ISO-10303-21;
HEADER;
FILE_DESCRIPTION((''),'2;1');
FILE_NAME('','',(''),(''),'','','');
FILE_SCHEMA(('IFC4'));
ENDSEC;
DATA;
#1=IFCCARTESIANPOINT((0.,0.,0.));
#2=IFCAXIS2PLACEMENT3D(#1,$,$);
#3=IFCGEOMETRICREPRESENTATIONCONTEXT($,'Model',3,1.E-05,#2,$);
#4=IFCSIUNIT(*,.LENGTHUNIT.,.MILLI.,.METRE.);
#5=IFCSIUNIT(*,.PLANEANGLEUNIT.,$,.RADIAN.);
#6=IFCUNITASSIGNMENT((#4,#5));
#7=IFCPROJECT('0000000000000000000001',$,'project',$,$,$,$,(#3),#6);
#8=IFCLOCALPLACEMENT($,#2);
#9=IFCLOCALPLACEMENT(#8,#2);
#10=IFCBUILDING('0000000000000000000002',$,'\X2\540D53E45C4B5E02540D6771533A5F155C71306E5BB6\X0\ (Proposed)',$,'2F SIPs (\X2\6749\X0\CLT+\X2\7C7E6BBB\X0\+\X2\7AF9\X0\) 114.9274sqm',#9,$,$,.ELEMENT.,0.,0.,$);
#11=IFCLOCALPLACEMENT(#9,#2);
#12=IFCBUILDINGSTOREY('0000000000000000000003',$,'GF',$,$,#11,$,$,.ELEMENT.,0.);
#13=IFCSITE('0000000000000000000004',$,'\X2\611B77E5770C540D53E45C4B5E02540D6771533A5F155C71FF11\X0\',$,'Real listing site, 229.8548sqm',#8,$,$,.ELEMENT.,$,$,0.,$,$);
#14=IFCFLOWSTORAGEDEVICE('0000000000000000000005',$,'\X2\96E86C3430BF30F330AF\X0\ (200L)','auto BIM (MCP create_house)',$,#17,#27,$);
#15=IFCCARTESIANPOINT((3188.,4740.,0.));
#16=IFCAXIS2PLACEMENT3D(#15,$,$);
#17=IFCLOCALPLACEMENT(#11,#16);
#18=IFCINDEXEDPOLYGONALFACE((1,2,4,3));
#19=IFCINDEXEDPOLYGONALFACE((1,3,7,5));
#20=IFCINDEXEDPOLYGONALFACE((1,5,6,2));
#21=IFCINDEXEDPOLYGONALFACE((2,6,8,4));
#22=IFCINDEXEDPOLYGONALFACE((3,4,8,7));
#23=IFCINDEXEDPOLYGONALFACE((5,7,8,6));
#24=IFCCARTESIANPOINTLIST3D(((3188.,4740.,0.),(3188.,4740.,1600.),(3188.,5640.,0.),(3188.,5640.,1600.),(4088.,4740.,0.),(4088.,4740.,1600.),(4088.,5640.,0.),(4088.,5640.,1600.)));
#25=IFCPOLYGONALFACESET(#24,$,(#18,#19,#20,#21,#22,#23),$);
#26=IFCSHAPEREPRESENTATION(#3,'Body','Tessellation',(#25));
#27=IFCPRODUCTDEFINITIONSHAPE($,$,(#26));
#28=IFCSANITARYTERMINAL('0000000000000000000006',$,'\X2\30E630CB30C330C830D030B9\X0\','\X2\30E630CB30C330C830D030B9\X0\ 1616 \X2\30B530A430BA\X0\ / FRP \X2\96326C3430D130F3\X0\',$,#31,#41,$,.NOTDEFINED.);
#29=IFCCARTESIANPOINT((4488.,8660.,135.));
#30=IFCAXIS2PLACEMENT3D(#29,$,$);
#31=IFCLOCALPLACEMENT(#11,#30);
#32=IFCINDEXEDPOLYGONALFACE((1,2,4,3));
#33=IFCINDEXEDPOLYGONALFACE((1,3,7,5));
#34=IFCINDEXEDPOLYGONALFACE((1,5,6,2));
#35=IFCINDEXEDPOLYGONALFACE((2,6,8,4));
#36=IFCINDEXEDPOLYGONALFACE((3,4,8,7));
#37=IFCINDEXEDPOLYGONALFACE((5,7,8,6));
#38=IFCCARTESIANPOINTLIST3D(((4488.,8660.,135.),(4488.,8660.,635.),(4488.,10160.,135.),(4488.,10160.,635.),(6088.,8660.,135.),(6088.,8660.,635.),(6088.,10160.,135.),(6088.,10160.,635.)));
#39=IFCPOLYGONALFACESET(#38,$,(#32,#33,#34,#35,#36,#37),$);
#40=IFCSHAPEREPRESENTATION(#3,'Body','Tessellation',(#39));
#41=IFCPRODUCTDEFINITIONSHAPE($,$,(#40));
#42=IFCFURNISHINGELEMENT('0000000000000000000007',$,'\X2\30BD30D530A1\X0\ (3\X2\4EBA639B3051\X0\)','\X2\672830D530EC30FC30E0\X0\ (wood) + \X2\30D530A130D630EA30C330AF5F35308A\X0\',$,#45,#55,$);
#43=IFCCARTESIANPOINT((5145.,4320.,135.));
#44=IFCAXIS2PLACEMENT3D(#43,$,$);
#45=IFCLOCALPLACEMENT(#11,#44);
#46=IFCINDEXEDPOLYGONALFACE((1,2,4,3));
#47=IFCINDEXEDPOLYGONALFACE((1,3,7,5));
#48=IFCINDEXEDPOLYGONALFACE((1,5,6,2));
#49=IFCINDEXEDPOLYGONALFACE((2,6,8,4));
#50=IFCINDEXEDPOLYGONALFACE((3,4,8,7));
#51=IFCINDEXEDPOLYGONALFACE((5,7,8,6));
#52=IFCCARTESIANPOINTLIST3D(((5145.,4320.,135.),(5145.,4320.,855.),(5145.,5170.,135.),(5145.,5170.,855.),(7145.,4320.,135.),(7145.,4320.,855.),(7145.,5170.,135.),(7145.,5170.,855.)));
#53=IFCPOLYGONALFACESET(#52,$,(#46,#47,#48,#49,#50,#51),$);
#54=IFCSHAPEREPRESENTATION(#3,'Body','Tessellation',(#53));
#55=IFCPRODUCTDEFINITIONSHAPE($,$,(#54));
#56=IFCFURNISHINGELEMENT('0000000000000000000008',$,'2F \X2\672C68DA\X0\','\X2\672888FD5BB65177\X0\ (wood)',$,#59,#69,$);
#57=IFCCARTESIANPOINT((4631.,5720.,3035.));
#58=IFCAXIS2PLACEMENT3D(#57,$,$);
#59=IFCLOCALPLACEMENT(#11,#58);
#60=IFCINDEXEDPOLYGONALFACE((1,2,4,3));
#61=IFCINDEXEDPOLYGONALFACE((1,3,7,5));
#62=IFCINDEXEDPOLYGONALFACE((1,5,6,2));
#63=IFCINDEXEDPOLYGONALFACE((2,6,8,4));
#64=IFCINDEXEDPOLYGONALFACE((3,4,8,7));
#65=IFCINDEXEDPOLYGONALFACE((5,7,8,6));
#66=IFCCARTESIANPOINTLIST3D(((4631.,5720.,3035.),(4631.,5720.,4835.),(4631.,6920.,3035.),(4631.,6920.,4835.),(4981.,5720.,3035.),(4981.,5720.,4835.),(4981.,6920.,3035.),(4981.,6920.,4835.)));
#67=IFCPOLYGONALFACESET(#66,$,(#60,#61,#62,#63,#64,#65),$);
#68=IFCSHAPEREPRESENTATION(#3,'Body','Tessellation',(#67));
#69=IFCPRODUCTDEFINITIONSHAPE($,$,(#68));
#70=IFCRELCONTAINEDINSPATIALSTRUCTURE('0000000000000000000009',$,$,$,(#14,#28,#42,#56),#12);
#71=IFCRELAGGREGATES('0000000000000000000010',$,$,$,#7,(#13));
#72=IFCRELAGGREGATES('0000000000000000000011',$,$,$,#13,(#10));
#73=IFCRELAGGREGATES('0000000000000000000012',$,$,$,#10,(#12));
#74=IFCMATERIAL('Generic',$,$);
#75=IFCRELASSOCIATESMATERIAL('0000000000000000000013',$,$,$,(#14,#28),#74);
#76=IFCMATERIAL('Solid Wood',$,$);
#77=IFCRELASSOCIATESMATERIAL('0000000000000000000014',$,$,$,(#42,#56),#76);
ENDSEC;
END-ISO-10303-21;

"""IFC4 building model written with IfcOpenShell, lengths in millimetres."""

from ifc_helpers import new_model, si_unit, frame, frame_2d, origin, place, context, project, spatial, rectangle, extrude, material, element, save


model = new_model("IFC4")

# Units and contexts
model_context = context("Model", 3, precision=1e-05, world=origin())
ifc_project = project(units=[si_unit("LENGTHUNIT", "METRE", prefix="MILLI"), si_unit("PLANEANGLEUNIT", "RADIAN")], contexts=[model_context])

# Site, building, storey
site_placement = place(None, origin())
site = spatial("IfcSite", under=ifc_project, at=site_placement, Name="愛知県名古屋市名東区引山１", ObjectType="Real listing site, 229.8548sqm", CompositionType="ELEMENT", RefElevation=0.0)
building_placement = place(site_placement, origin())
building = spatial("IfcBuilding", under=site, at=building_placement, Name="名古屋市名東区引山の家 (Proposed)", ObjectType="2F SIPs (杉CLT+籾殻+竹) 114.9274sqm", CompositionType="ELEMENT", ElevationOfRefHeight=0.0, ElevationOfTerrain=0.0)
storey_placement = place(building_placement, origin())
storey = spatial("IfcBuildingStorey", under=building, at=storey_placement, Name="GF", CompositionType="ELEMENT", Elevation=0.0)

# Shared definitions
ifc_material_1 = material(Name="Solid Wood")

# Shared definitions
ifc_material_2 = material(Name="Generic")

# Flow storage device
flow_storage_device_placement = place(storey_placement, frame((3188.0, 4740.0, 0.0)))
element("IfcFlowStorageDevice", 1, at=flow_storage_device_placement, inside=storey, material=ifc_material_2, Name="雨水タンク (200L)", Description="auto BIM (MCP create_house)", context=model_context, shape_type="SweptSolid", body=[
    extrude(rectangle(XDim=900.0, YDim=900.0, at=frame_2d((450.0, 450.0))), frame((3188.0, 4740.0, 0.0)), (0.0, 0.0, 1.0), 1600.0),
])

# Sanitary terminal
sanitary_terminal_placement = place(storey_placement, frame((4488.0, 8660.0, 135.0)))
element("IfcSanitaryTerminal", 2, at=sanitary_terminal_placement, inside=storey, material=ifc_material_2, Name="ユニットバス", Description="ユニットバス 1616 サイズ / FRP 防水パン", PredefinedType="NOTDEFINED", context=model_context, shape_type="SweptSolid", body=[
    extrude(rectangle(XDim=1600.0, YDim=1500.0, at=frame_2d((800.0, 750.0))), frame((4488.0, 8660.0, 135.0)), (0.0, 0.0, 1.0), 500.0),
])

# Furnishing elements
furnishing_1_placement = place(storey_placement, frame((5145.0, 4320.0, 135.0)))
element("IfcFurnishingElement", 3, at=furnishing_1_placement, inside=storey, material=ifc_material_1, Name="ソファ (3人掛け)", Description="木フレーム (wood) + ファブリック張り", context=model_context, shape_type="SweptSolid", body=[
    extrude(rectangle(XDim=2000.0, YDim=850.0, at=frame_2d((1000.0, 425.0))), frame((5145.0, 4320.0, 135.0)), (0.0, 0.0, 1.0), 720.0),
])
furnishing_2_placement = place(storey_placement, frame((4631.0, 5720.0, 3035.0)))
element("IfcFurnishingElement", 4, at=furnishing_2_placement, inside=storey, material=ifc_material_1, Name="2F 本棚", Description="木製家具 (wood)", context=model_context, shape_type="SweptSolid", body=[
    extrude(rectangle(XDim=350.0, YDim=1200.0, at=frame_2d((175.0, 600.0))), frame((4631.0, 5720.0, 3035.0)), (0.0, 0.0, 1.0), 1800.0),
])

save(model, "model.ifc")
